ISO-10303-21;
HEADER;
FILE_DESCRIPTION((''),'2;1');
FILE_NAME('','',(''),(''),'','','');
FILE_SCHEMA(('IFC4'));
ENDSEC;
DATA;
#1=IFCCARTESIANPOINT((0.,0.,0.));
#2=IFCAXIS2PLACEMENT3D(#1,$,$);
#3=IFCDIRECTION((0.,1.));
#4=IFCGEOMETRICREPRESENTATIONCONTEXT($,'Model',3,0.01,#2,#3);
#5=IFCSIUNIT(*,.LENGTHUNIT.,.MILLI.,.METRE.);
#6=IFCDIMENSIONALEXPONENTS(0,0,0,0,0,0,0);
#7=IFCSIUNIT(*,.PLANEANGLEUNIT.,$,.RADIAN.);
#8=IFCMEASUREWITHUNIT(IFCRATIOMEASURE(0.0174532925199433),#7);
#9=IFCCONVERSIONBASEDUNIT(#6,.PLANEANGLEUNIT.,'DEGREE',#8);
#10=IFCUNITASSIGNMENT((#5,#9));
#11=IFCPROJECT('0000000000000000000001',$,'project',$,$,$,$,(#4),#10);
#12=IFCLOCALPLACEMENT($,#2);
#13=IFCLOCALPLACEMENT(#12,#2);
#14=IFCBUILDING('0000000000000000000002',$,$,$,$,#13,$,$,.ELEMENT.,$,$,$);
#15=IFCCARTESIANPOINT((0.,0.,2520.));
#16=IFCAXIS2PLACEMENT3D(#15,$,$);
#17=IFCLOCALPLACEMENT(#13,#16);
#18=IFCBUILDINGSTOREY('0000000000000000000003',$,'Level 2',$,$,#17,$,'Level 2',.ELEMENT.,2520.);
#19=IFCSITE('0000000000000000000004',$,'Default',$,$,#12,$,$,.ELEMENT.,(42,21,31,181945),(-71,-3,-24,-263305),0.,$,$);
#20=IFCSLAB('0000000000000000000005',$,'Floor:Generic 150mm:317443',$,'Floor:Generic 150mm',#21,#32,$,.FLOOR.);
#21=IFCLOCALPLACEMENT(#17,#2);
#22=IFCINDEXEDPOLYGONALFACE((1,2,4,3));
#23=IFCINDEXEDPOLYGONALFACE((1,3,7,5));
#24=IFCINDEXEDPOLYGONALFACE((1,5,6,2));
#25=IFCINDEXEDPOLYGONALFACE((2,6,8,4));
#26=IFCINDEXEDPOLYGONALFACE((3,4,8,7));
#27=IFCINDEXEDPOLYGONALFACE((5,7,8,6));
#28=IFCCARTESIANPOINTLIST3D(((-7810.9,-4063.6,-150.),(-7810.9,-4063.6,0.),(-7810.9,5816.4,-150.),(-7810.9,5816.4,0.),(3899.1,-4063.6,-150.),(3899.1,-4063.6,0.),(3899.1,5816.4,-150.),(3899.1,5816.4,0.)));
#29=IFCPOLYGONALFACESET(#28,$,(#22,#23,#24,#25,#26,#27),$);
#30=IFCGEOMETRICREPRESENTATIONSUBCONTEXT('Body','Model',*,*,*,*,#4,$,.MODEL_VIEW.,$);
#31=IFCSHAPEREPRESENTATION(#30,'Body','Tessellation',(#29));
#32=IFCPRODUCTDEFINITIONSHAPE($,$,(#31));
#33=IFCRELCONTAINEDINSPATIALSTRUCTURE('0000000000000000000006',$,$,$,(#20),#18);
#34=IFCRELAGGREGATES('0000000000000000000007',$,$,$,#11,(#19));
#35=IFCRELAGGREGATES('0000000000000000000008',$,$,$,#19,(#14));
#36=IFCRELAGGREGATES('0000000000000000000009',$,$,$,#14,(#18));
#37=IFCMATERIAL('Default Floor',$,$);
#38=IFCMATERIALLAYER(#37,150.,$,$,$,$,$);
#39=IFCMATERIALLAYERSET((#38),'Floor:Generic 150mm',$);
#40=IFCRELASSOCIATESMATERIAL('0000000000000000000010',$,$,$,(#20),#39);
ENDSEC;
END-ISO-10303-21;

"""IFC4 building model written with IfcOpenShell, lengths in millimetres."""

from ifc_helpers import new_model, entity, si_unit, converted_unit, direction, frame, origin, origin_2d_with_axis, place, context, subcontext, project, spatial, rectangle, extrude, material, layer, layer_set, layer_usage, element, save


model = new_model("IFC4")

# Units and contexts
model_context = context("Model", 3, precision=0.01, world=origin(), true_north=direction((0.0, 1.0)))
body_context = subcontext(model_context, "Body", "Model", "MODEL_VIEW")
ifc_project = project(units=[si_unit("LENGTHUNIT", "METRE", prefix="MILLI"), converted_unit("PLANEANGLEUNIT", "DEGREE", entity("IfcRatioMeasure", 0.0174532925199433), si_unit("PLANEANGLEUNIT", "RADIAN"), dimensions=[0, 0, 0, 0, 0, 0, 0])], contexts=[model_context])

# Site, building, storey
site_placement = place(None, origin())
site = spatial("IfcSite", under=ifc_project, at=site_placement, Name="Default", CompositionType="ELEMENT", RefLatitude=(42, 21, 31, 181945), RefLongitude=(-71, -3, -24, -263305), RefElevation=0.0)
building_placement = place(site_placement, origin())
building = spatial("IfcBuilding", under=site, at=building_placement, CompositionType="ELEMENT")
storey_placement = place(building_placement, frame((0.0, 0.0, 2520.0)))
storey = spatial("IfcBuildingStorey", under=building, at=storey_placement, Name="Level 2", LongName="Level 2", CompositionType="ELEMENT", Elevation=2520.0)

# Slab
ifc_material = material(Name="Default Floor")
ifc_layer = layer(ifc_material, 150.0)
ifc_layer_set = layer_set([ifc_layer], Name="Floor:Generic 150mm")
ifc_layer_usage = layer_usage(ifc_layer_set, "AXIS3", "POSITIVE", 0.0)
slab_placement = place(storey_placement, origin())
element("IfcSlab", 1, at=slab_placement, inside=storey, material=ifc_layer_usage, Name="Floor:Generic 150mm:317443", ObjectType="Floor:Generic 150mm", PredefinedType="FLOOR", context=body_context, shape_type="SweptSolid", body=[
    extrude(rectangle(XDim=9880.0, YDim=11710.0, at=origin_2d_with_axis()), frame((-1955.9, 876.4, 0.0), z_axis=(0.0, 0.0, -1.0), x_axis=(0.0, 1.0, 0.0)), (0.0, 0.0, 1.0), 150.0),
])

save(model, "model.ifc")
